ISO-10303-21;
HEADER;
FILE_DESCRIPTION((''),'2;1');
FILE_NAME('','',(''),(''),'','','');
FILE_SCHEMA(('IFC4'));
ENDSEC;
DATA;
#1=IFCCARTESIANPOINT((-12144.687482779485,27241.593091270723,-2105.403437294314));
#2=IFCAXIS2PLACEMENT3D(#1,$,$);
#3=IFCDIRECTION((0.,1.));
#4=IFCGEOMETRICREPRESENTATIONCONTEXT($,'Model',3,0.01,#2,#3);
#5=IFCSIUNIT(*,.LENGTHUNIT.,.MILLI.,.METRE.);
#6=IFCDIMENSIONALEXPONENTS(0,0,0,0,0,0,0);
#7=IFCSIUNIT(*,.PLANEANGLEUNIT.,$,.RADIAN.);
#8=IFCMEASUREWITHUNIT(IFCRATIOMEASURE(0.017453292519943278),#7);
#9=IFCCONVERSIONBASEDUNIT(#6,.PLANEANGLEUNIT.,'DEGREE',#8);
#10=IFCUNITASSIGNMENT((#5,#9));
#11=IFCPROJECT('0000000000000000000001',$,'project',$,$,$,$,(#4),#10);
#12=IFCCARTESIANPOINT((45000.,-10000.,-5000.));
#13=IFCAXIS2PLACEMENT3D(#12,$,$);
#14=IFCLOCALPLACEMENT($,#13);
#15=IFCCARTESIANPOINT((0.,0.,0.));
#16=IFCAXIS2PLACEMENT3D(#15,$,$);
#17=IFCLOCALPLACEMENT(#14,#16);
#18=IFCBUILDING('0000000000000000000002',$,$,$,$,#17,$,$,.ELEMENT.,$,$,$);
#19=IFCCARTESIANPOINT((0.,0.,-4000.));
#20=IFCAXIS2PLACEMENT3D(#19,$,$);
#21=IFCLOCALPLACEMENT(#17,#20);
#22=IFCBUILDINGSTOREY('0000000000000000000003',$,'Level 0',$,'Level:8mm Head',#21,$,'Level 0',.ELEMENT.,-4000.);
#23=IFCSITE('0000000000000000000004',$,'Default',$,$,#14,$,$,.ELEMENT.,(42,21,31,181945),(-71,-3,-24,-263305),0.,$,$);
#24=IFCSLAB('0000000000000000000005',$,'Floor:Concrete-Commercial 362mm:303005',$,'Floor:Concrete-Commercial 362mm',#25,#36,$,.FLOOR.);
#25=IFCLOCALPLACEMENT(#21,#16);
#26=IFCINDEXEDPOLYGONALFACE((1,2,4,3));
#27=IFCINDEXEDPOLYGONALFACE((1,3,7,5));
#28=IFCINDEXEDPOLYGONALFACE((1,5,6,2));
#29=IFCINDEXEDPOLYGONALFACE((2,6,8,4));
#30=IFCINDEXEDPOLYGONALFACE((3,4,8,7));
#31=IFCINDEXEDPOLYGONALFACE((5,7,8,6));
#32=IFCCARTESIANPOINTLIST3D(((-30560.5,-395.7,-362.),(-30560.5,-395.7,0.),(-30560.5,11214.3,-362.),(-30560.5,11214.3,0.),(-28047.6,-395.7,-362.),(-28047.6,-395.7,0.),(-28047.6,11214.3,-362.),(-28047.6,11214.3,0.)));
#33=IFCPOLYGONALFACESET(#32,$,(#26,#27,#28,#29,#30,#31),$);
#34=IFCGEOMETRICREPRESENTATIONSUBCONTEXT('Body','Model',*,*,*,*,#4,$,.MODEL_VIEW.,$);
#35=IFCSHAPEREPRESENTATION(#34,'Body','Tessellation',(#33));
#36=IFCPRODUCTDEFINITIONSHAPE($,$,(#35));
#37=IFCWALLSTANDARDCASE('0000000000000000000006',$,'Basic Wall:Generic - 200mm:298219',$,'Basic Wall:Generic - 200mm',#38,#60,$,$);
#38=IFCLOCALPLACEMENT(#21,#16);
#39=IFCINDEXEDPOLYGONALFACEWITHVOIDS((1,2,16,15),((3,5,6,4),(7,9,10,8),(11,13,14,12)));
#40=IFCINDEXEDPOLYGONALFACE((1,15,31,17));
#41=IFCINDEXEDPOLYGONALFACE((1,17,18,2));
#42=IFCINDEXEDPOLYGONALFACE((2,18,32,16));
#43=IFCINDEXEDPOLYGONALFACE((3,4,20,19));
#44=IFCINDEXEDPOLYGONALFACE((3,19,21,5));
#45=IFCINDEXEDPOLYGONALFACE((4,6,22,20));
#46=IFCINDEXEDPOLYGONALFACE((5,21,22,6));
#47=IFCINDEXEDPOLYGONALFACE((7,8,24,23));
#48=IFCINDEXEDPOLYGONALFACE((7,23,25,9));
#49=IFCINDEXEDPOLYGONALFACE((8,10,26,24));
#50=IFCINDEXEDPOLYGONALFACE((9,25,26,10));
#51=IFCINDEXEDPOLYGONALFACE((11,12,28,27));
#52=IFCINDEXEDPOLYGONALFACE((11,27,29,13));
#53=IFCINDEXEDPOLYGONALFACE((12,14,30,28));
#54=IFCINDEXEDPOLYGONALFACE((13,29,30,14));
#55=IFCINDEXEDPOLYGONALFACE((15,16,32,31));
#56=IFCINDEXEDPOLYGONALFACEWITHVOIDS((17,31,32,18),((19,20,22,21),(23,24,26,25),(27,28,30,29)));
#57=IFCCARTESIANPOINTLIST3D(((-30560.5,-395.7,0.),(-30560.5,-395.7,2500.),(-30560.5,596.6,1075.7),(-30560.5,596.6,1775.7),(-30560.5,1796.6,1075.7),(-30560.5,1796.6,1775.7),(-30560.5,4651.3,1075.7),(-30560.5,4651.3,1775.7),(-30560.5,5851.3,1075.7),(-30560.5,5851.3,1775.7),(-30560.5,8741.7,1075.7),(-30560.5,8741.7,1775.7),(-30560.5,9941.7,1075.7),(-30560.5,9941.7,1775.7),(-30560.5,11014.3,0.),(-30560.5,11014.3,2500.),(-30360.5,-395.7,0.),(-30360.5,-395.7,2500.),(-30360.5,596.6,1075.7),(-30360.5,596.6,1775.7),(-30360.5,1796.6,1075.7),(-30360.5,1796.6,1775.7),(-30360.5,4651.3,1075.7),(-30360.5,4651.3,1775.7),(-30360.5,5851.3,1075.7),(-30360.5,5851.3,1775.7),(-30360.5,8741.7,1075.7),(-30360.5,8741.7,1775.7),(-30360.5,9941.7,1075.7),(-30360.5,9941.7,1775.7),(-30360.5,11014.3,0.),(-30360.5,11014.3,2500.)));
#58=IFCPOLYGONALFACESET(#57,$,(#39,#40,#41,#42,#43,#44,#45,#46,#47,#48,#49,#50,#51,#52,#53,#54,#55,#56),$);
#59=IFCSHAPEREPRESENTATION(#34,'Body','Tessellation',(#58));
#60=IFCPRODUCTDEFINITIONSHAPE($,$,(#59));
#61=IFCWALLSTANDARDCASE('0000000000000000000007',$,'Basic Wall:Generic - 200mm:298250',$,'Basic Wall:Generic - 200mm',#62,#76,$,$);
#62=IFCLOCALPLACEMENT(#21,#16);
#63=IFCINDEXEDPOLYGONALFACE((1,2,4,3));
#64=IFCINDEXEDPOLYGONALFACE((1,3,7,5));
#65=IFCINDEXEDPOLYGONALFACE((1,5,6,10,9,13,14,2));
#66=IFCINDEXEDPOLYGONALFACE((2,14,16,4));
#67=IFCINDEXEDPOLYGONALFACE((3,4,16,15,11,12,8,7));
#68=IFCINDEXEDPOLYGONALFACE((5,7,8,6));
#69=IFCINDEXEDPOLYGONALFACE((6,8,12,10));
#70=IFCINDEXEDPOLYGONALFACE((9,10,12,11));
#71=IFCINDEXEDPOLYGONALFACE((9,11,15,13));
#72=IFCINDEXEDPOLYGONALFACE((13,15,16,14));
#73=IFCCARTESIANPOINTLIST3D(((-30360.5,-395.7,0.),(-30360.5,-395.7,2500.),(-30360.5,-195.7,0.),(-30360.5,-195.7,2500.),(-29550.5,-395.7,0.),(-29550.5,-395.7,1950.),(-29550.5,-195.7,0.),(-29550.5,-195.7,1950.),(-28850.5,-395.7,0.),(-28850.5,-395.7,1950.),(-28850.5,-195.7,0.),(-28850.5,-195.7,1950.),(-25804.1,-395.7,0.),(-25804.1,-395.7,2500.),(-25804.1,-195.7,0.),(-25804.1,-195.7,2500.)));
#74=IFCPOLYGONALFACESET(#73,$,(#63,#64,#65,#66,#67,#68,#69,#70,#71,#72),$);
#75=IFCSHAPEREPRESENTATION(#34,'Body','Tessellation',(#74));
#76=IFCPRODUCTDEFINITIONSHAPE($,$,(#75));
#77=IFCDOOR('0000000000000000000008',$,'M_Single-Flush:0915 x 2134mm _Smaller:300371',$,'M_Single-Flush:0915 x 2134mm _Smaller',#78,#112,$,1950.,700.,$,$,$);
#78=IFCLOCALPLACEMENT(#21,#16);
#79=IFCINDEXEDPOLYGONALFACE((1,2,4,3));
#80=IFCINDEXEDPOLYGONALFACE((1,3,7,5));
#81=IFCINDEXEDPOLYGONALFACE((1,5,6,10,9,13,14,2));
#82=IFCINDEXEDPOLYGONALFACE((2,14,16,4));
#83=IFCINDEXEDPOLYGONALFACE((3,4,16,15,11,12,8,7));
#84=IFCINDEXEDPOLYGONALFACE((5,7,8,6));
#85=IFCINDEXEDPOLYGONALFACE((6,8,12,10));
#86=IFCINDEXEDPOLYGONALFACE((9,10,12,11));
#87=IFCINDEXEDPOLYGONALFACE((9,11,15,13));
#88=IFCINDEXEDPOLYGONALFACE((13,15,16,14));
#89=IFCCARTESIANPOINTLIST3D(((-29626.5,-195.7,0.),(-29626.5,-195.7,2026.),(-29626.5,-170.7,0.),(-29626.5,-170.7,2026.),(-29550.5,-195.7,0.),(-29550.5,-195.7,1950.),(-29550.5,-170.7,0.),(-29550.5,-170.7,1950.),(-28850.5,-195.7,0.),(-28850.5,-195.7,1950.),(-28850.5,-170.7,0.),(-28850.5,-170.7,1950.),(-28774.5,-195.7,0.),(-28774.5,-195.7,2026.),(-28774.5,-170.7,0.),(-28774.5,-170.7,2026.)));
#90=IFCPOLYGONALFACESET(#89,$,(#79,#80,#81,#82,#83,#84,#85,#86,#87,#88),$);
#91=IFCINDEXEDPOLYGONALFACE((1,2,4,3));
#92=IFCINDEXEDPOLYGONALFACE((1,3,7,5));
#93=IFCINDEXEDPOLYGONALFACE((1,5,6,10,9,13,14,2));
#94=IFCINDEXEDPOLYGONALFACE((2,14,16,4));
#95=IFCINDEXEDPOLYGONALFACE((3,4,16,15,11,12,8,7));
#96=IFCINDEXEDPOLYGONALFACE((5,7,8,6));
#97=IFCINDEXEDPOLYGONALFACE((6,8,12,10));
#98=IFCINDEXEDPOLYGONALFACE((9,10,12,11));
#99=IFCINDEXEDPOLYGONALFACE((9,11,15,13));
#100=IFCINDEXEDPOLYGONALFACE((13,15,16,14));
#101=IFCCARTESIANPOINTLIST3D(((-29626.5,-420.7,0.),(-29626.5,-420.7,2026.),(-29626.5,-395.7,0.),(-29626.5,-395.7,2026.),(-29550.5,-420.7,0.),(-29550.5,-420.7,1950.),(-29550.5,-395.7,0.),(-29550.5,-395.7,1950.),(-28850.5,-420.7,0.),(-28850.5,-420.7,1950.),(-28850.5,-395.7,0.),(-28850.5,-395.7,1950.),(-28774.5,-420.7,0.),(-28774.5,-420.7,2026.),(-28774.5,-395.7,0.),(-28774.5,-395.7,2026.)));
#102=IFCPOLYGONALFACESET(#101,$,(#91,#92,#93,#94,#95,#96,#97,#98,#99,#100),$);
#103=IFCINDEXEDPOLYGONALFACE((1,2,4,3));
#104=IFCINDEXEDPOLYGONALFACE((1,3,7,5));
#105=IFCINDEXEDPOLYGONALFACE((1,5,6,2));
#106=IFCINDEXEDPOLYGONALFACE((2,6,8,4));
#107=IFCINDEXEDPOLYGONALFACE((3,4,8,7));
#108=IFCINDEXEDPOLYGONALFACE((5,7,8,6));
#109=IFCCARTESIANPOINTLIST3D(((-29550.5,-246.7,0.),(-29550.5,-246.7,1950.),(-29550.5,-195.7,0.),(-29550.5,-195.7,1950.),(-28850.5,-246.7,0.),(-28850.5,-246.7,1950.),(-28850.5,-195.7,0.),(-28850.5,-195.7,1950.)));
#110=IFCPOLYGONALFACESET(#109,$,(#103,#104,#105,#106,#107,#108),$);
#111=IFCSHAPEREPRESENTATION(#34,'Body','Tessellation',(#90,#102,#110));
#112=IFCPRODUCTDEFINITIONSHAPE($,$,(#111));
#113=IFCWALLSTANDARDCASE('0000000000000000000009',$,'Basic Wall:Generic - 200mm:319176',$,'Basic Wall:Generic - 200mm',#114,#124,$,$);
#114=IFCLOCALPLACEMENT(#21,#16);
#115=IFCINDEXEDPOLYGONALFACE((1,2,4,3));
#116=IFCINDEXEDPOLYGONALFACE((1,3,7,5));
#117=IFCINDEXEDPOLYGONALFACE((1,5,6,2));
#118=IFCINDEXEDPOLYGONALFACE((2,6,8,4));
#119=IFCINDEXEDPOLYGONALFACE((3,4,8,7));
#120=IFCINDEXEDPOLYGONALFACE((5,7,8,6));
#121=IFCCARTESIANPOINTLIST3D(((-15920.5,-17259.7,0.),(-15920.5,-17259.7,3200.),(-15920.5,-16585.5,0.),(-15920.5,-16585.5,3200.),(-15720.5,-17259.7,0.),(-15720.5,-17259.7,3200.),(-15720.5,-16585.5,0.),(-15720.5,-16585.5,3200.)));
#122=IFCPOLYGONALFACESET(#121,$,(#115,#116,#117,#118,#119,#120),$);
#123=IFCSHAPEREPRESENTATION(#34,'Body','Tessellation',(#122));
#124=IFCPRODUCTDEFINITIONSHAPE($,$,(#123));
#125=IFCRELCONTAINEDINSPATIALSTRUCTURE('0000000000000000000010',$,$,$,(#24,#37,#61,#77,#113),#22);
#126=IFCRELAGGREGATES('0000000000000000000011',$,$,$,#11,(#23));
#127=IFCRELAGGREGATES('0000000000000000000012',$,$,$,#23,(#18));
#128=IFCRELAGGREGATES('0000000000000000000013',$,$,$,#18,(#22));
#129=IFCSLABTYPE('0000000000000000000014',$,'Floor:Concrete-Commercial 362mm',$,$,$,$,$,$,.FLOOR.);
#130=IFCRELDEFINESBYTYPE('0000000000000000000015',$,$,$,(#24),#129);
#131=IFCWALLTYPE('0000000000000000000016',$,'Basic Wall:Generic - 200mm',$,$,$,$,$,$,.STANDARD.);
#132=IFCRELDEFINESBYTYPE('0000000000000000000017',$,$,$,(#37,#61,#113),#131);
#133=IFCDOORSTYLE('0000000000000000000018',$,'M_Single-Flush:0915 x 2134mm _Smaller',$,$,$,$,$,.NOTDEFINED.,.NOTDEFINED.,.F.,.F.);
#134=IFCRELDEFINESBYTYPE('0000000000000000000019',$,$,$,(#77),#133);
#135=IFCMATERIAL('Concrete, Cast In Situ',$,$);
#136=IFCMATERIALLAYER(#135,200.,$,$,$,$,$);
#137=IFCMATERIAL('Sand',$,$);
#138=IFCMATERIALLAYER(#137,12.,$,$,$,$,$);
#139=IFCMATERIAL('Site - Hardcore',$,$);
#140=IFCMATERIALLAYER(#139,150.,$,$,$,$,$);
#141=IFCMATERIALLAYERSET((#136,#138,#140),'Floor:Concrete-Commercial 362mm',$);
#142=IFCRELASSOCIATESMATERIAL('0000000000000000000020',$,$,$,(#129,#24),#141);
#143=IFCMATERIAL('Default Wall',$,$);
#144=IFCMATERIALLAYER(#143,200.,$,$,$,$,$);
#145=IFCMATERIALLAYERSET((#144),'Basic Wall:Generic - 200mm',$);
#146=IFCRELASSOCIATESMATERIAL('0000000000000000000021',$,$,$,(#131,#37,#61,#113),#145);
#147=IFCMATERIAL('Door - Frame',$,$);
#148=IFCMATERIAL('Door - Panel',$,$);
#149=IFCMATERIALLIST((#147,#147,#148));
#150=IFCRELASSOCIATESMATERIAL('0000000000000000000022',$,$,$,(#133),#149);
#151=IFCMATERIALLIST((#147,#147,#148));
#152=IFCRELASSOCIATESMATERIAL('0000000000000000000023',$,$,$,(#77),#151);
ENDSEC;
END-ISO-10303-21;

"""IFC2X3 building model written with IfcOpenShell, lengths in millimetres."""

from ifc_helpers import new_model, entity, si_unit, converted_unit, direction, frame, frame_2d, origin, origin_2d_with_axis, place, context, subcontext, project, spatial, polyline, rectangle, outline, extrude, clip, bounded_halfspace, source, transform, mapped, material, material_list, layer, layer_set, layer_usage, type_object, type_shapes, element, fill, save


model = new_model("IFC2X3")

# Units and contexts
model_context = context("Model", 3, precision=0.01, world=frame((-12144.687482779485, 27241.593091270723, -2105.403437294314)), true_north=direction((0.0, 1.0)))
body_context = subcontext(model_context, "Body", "Model", "MODEL_VIEW")
ifc_project = project(units=[si_unit("LENGTHUNIT", "METRE", prefix="MILLI"), converted_unit("PLANEANGLEUNIT", "DEGREE", entity("IfcRatioMeasure", 0.017453292519943278), si_unit("PLANEANGLEUNIT", "RADIAN"), dimensions=[0, 0, 0, 0, 0, 0, 0])], contexts=[model_context])

# Site, building, storey
site_placement = place(None, frame((45000.0, -10000.0, -5000.0)))
site = spatial("IfcSite", under=ifc_project, at=site_placement, Name="Default", CompositionType="ELEMENT", RefLatitude=(42, 21, 31, 181945), RefLongitude=(-71, -3, -24, -263305), RefElevation=0.0)
building_placement = place(site_placement, origin())
building = spatial("IfcBuilding", under=site, at=building_placement, CompositionType="ELEMENT")
storey_placement = place(building_placement, frame((0.0, 0.0, -4000.0)))
storey = spatial("IfcBuildingStorey", under=building, at=storey_placement, Name="Level 0", ObjectType="Level:8mm Head", LongName="Level 0", CompositionType="ELEMENT", Elevation=-4000.0)

# Slab
ifc_material_1 = material(Name="Concrete, Cast In Situ")
ifc_layer_1 = layer(ifc_material_1, 200.0)
ifc_material_2 = material(Name="Sand")
ifc_layer_2 = layer(ifc_material_2, 12.0)
ifc_material_3 = material(Name="Site - Hardcore")
ifc_layer_3 = layer(ifc_material_3, 150.0)
ifc_layer_set_1 = layer_set([ifc_layer_1, ifc_layer_2, ifc_layer_3], Name="Floor:Concrete-Commercial 362mm")
ifc_layer_usage_1 = layer_usage(ifc_layer_set_1, "AXIS3", "POSITIVE", 0.0)
slab_type = type_object("IfcSlabType", Name="Floor:Concrete-Commercial 362mm", PredefinedType="FLOOR", material=ifc_layer_set_1)
slab_placement = place(storey_placement, origin())
element("IfcSlab", 1, at=slab_placement, inside=storey, type_object=slab_type, material=ifc_layer_usage_1, Name="Floor:Concrete-Commercial 362mm:303005", ObjectType="Floor:Concrete-Commercial 362mm", PredefinedType="FLOOR", context=body_context, shape_type="SweptSolid", body=[
    extrude(rectangle(XDim=11610.0, YDim=2512.8, at=origin_2d_with_axis()), frame((-29304.1, 5409.3, 0.0), z_axis=(0.0, 0.0, -1.0), x_axis=(0.0, 1.0, 0.0)), (0.0, 0.0, 1.0), 362.0),
])

# Shared definitions
ifc_material_4 = material(Name="Default Wall")
ifc_layer_4 = layer(ifc_material_4, 200.0)
ifc_layer_set_2 = layer_set([ifc_layer_4], Name="Basic Wall:Generic - 200mm")
wall_type = type_object("IfcWallType", Name="Basic Wall:Generic - 200mm", PredefinedType="STANDARD", material=ifc_layer_set_2)

# Wall, openings
ifc_layer_usage_2 = layer_usage(ifc_layer_set_2, "AXIS2", "NEGATIVE", 100.0)
wall_1_placement = place(storey_placement, frame((-30460.5, 11014.3, 0.0), z_axis=(0.0, 0.0, 1.0), x_axis=(0.0, -1.0, 0.0)))
wall_1 = element("IfcWallStandardCase", 2, at=wall_1_placement, inside=storey, type_object=wall_type, material=ifc_layer_usage_2, Name="Basic Wall:Generic - 200mm:298219", ObjectType="Basic Wall:Generic - 200mm", context=body_context, shape_type="Clipping", body=[
    clip(extrude(rectangle(XDim=11410.0, YDim=200.0, at=frame_2d((5705.0, 0.0), x_axis=(-1.0, 0.0))), origin(), (0.0, 0.0, 1.0), 2500.0), bounded_halfspace(frame((0.0, -100.0, 2500.0), z_axis=(0.0, 0.0, -1.0), x_axis=(0.0, 1.0, 0.0)), True, frame((0.0, -100.0, 2500.0)), polyline([(0.0, 0.0), (3477782.0, 0.0), (3477782.0, 60960.0), (3416822.0, 60960.0), (0.0, 60960.0), (0.0, 0.0)]))),
])
opening_1_placement = place(wall_1_placement, frame((1072.6, -100.0, 1075.7)))
element("IfcOpeningElement", 3, at=opening_1_placement, cuts=wall_1, ObjectType="Opening", context=body_context, shape_type="SweptSolid", body=[
    extrude(rectangle(XDim=700.0, YDim=1200.0, at=frame_2d((350.0, 600.0), x_axis=(-1.0, 0.0))), frame((0.0, 0.0, 0.0), z_axis=(0.0, 1.0, 0.0), x_axis=(0.0, 0.0, 1.0)), (0.0, 0.0, 1.0), 200.0),
])
opening_2_placement = place(wall_1_placement, frame((5163.0, -100.0, 1075.7)))
element("IfcOpeningElement", 4, at=opening_2_placement, cuts=wall_1, ObjectType="Opening", context=body_context, shape_type="SweptSolid", body=[
    extrude(rectangle(XDim=700.0, YDim=1200.0, at=frame_2d((350.0, 600.0), x_axis=(-1.0, 0.0))), frame((0.0, 0.0, 0.0), z_axis=(0.0, 1.0, 0.0), x_axis=(0.0, 0.0, 1.0)), (0.0, 0.0, 1.0), 200.0),
])
opening_3_placement = place(wall_1_placement, frame((9217.8, -100.0, 1075.7)))
element("IfcOpeningElement", 5, at=opening_3_placement, cuts=wall_1, ObjectType="Opening", context=body_context, shape_type="SweptSolid", body=[
    extrude(rectangle(XDim=700.0, YDim=1200.0, at=frame_2d((350.0, 600.0), x_axis=(-1.0, 0.0))), frame((0.0, 0.0, 0.0), z_axis=(0.0, 1.0, 0.0), x_axis=(0.0, 0.0, 1.0)), (0.0, 0.0, 1.0), 200.0),
])

# Wall, opening, door
ifc_layer_usage_3 = layer_usage(ifc_layer_set_2, "AXIS2", "NEGATIVE", 100.0)
wall_2_placement = place(storey_placement, frame((-30360.5, -295.7, 0.0)))
wall_2 = element("IfcWallStandardCase", 6, at=wall_2_placement, inside=storey, type_object=wall_type, material=ifc_layer_usage_3, Name="Basic Wall:Generic - 200mm:298250", ObjectType="Basic Wall:Generic - 200mm", context=body_context, shape_type="Clipping", body=[
    clip(extrude(rectangle(XDim=200.0, YDim=4556.4, at=frame_2d((2278.2, 0.0), x_axis=(0.0, -1.0))), origin(), (0.0, 0.0, 1.0), 2500.0), bounded_halfspace(frame((0.0, 100.0, 2500.0), z_axis=(0.0, 0.0, -1.0), x_axis=(1.0, 0.0, 0.0)), True, frame((0.0, 100.0, 2500.0)), polyline([(0.0, 0.0), (0.0, -60960.0), (1388794.7, -60960.0), (1388794.7, 0.0), (0.0, 0.0)]))),
])
opening_4_placement = place(wall_2_placement, frame((810.0, -100.0, 0.0)))
opening_4 = element("IfcOpeningElement", 7, at=opening_4_placement, cuts=wall_2, ObjectType="Opening", context=body_context, shape_type="SweptSolid", body=[
    extrude(rectangle(XDim=700.0, YDim=1950.0, at=frame_2d((975.0, 350.0), x_axis=(0.0, -1.0))), frame((0.0, 0.0, 0.0), z_axis=(0.0, 1.0, 0.0), x_axis=(0.0, 0.0, 1.0)), (0.0, 0.0, 1.0), 200.0),
])
ifc_material_5 = material(Name="Door - Frame")
ifc_material_6 = material(Name="Door - Panel")
ifc_material_list_1 = material_list([ifc_material_5, ifc_material_5, ifc_material_6])
ifc_material_list_2 = material_list([ifc_material_5, ifc_material_5, ifc_material_6])
door_style = type_object("IfcDoorStyle", Name="M_Single-Flush:0915 x 2134mm _Smaller", ConstructionType="NOTDEFINED", OperationType="NOTDEFINED", ParameterTakesPrecedence=False, Sizeable=False, material=ifc_material_list_2)
shared_shape = source(origin(), body_context, "Body", "SweptSolid", [
    extrude(outline(polyline([(-426.0, -1032.0), (426.0, -1032.0), (426.0, 994.0), (350.0, 994.0), (350.0, -956.0), (-350.0, -956.0), (-350.0, 994.0), (-426.0, 994.0), (-426.0, -1032.0)])), frame((350.0, 225.0, 994.0), z_axis=(0.0, -1.0, 0.0), x_axis=(-1.0, 0.0, 0.0)), (0.0, 0.0, 1.0), 25.0),
    extrude(outline(polyline([(-1032.0, -426.0), (994.0, -426.0), (994.0, -350.0), (-956.0, -350.0), (-956.0, 350.0), (994.0, 350.0), (994.0, 426.0), (-1032.0, 426.0), (-1032.0, -426.0)])), frame((350.0, 0.0, 994.0), z_axis=(0.0, -1.0, 0.0), x_axis=(0.0, 0.0, -1.0)), (0.0, 0.0, 1.0), 25.0),
    extrude(rectangle(XDim=700.0, YDim=51.0, at=frame_2d((0.0, 0.0), x_axis=(1.0, 0.0))), frame((350.0, 174.5, 0.0)), (0.0, 0.0, 1.0), 1950.0),
])
type_shapes(door_style, [shared_shape])
door_placement = place(opening_4_placement, origin())
door = element("IfcDoor", 8, at=door_placement, inside=storey, type_object=door_style, material=ifc_material_list_1, Name="M_Single-Flush:0915 x 2134mm _Smaller:300371", ObjectType="M_Single-Flush:0915 x 2134mm _Smaller", OverallHeight=1950.0, OverallWidth=700.0, context=body_context, shape_type="MappedRepresentation", body=[
    mapped(shared_shape, transform((0.0, 0.0, 0.0), scale=1.0)),
])
fill(opening_4, door)

# Wall
ifc_layer_usage_4 = layer_usage(ifc_layer_set_2, "AXIS2", "NEGATIVE", 100.0)
wall_3_placement = place(storey_placement, frame((-15820.5, -16585.5, 0.0), z_axis=(0.0, 0.0, 1.0), x_axis=(0.0, -1.0, 0.0)))
element("IfcWallStandardCase", 9, at=wall_3_placement, inside=storey, type_object=wall_type, material=ifc_layer_usage_4, Name="Basic Wall:Generic - 200mm:319176", ObjectType="Basic Wall:Generic - 200mm", context=body_context, shape_type="SweptSolid", body=[
    extrude(rectangle(XDim=674.2, YDim=200.0, at=frame_2d((337.1, 0.0), x_axis=(-1.0, 0.0))), origin(), (0.0, 0.0, 1.0), 3200.0),
])

save(model, "model.ifc")
